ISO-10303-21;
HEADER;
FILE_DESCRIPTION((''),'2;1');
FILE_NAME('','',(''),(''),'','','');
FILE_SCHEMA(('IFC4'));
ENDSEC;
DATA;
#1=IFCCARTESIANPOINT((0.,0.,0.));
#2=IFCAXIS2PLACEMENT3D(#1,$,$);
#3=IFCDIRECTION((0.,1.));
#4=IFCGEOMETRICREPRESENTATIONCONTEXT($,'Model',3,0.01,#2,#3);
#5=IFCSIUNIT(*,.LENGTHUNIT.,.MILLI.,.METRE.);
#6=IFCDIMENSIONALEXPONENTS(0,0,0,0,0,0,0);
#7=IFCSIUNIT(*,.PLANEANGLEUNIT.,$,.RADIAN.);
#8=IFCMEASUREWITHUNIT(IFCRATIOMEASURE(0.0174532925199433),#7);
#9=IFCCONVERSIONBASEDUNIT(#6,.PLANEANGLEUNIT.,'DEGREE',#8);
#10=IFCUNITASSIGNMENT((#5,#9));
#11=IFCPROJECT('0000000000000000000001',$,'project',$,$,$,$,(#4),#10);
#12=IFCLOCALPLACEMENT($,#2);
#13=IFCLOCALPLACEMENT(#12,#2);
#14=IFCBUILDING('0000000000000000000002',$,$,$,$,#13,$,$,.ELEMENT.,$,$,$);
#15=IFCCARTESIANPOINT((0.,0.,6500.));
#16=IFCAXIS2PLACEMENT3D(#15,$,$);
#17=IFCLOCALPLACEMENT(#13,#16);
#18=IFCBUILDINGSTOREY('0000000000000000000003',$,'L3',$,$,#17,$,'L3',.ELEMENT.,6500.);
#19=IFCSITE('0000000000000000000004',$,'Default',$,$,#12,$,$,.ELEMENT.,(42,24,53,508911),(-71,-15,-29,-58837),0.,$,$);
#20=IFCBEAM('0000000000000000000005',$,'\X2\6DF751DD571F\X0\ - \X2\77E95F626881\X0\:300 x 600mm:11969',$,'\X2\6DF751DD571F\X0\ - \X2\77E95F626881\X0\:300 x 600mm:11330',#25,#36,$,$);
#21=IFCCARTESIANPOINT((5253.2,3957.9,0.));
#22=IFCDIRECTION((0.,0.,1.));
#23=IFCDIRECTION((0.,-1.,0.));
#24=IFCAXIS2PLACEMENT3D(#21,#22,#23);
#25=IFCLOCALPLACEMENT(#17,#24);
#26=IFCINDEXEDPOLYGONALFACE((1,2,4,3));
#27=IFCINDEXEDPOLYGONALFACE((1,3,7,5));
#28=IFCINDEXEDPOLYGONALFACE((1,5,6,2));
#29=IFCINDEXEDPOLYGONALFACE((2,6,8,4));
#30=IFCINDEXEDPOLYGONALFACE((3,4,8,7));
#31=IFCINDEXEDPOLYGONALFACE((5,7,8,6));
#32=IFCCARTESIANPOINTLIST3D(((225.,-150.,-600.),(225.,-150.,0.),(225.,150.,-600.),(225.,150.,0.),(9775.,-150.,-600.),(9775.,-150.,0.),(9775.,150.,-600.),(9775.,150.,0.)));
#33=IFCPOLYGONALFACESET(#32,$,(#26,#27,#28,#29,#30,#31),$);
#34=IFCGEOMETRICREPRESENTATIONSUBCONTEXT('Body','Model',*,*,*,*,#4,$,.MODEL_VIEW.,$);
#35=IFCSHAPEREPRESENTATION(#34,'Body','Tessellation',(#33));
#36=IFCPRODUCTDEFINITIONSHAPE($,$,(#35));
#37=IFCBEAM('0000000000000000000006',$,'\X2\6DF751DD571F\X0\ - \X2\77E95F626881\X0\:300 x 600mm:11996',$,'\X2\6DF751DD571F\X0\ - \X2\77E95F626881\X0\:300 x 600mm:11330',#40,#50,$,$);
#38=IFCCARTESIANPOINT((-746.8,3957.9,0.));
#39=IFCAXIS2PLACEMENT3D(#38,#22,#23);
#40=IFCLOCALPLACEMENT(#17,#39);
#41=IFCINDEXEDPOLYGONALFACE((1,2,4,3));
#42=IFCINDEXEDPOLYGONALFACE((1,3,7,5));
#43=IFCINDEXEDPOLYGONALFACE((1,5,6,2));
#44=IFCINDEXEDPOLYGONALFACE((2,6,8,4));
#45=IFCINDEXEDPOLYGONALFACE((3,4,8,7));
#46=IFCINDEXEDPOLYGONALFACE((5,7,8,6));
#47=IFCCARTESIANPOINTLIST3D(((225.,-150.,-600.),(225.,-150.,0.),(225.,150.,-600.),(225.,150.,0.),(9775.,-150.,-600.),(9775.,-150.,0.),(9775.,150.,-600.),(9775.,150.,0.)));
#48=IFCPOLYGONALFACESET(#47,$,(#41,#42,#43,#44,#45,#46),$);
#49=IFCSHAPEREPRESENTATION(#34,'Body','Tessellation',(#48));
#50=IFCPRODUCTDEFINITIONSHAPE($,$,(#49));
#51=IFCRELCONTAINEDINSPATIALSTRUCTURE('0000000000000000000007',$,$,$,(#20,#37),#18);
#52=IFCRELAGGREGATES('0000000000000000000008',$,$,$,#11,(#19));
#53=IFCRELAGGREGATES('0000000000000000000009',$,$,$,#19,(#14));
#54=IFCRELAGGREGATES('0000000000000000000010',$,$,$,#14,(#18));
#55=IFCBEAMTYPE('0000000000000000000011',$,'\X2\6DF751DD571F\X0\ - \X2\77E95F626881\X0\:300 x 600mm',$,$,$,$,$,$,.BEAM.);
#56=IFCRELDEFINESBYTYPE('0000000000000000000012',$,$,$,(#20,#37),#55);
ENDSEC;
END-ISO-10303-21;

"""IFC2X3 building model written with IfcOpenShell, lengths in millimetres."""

from ifc_helpers import new_model, entity, si_unit, converted_unit, direction, frame, frame_2d, origin, place, context, subcontext, project, spatial, rectangle, extrude, type_object, element, save


model = new_model("IFC2X3")

# Units and contexts
model_context = context("Model", 3, precision=0.01, world=origin(), true_north=direction((0.0, 1.0)))
body_context = subcontext(model_context, "Body", "Model", "MODEL_VIEW")
ifc_project = project(units=[si_unit("LENGTHUNIT", "METRE", prefix="MILLI"), converted_unit("PLANEANGLEUNIT", "DEGREE", entity("IfcRatioMeasure", 0.0174532925199433), si_unit("PLANEANGLEUNIT", "RADIAN"), dimensions=[0, 0, 0, 0, 0, 0, 0])], contexts=[model_context])

# Site, building, storey
site_placement = place(None, origin())
site = spatial("IfcSite", under=ifc_project, at=site_placement, Name="Default", CompositionType="ELEMENT", RefLatitude=(42, 24, 53, 508911), RefLongitude=(-71, -15, -29, -58837), RefElevation=0.0)
building_placement = place(site_placement, origin())
building = spatial("IfcBuilding", under=site, at=building_placement, CompositionType="ELEMENT")
storey_placement = place(building_placement, frame((0.0, 0.0, 6500.0)))
storey = spatial("IfcBuildingStorey", under=building, at=storey_placement, Name="L3", LongName="L3", CompositionType="ELEMENT", Elevation=6500.0)

# Beams
beam_type_1 = type_object("IfcBeamType", Name="混凝土 - 矩形梁:300 x 600mm", PredefinedType="BEAM")
beam_1_placement = place(storey_placement, frame((5253.2, 3957.9, 0.0), z_axis=(0.0, 0.0, 1.0), x_axis=(0.0, -1.0, 0.0)))
element("IfcBeam", 1, at=beam_1_placement, inside=storey, type_object=beam_type_1, Name="混凝土 - 矩形梁:300 x 600mm:11969", ObjectType="混凝土 - 矩形梁:300 x 600mm:11330", context=body_context, shape_type="SweptSolid", body=[
    extrude(rectangle(XDim=600.0, YDim=300.0, at=frame_2d((0.0, 0.0), x_axis=(1.0, 0.0))), frame((225.0, 0.0, -300.0), z_axis=(1.0, 0.0, 0.0), x_axis=(0.0, 0.0, -1.0)), (0.0, 0.0, 1.0), 9550.0),
])
beam_2_placement = place(storey_placement, frame((-746.8, 3957.9, 0.0), z_axis=(0.0, 0.0, 1.0), x_axis=(0.0, -1.0, 0.0)))
element("IfcBeam", 2, at=beam_2_placement, inside=storey, type_object=beam_type_1, Name="混凝土 - 矩形梁:300 x 600mm:11996", ObjectType="混凝土 - 矩形梁:300 x 600mm:11330", context=body_context, shape_type="SweptSolid", body=[
    extrude(rectangle(XDim=600.0, YDim=300.0, at=frame_2d((0.0, 0.0), x_axis=(1.0, 0.0))), frame((225.0, 0.0, -300.0), z_axis=(1.0, 0.0, 0.0), x_axis=(0.0, 0.0, -1.0)), (0.0, 0.0, 1.0), 9550.0),
])

save(model, "model.ifc")
